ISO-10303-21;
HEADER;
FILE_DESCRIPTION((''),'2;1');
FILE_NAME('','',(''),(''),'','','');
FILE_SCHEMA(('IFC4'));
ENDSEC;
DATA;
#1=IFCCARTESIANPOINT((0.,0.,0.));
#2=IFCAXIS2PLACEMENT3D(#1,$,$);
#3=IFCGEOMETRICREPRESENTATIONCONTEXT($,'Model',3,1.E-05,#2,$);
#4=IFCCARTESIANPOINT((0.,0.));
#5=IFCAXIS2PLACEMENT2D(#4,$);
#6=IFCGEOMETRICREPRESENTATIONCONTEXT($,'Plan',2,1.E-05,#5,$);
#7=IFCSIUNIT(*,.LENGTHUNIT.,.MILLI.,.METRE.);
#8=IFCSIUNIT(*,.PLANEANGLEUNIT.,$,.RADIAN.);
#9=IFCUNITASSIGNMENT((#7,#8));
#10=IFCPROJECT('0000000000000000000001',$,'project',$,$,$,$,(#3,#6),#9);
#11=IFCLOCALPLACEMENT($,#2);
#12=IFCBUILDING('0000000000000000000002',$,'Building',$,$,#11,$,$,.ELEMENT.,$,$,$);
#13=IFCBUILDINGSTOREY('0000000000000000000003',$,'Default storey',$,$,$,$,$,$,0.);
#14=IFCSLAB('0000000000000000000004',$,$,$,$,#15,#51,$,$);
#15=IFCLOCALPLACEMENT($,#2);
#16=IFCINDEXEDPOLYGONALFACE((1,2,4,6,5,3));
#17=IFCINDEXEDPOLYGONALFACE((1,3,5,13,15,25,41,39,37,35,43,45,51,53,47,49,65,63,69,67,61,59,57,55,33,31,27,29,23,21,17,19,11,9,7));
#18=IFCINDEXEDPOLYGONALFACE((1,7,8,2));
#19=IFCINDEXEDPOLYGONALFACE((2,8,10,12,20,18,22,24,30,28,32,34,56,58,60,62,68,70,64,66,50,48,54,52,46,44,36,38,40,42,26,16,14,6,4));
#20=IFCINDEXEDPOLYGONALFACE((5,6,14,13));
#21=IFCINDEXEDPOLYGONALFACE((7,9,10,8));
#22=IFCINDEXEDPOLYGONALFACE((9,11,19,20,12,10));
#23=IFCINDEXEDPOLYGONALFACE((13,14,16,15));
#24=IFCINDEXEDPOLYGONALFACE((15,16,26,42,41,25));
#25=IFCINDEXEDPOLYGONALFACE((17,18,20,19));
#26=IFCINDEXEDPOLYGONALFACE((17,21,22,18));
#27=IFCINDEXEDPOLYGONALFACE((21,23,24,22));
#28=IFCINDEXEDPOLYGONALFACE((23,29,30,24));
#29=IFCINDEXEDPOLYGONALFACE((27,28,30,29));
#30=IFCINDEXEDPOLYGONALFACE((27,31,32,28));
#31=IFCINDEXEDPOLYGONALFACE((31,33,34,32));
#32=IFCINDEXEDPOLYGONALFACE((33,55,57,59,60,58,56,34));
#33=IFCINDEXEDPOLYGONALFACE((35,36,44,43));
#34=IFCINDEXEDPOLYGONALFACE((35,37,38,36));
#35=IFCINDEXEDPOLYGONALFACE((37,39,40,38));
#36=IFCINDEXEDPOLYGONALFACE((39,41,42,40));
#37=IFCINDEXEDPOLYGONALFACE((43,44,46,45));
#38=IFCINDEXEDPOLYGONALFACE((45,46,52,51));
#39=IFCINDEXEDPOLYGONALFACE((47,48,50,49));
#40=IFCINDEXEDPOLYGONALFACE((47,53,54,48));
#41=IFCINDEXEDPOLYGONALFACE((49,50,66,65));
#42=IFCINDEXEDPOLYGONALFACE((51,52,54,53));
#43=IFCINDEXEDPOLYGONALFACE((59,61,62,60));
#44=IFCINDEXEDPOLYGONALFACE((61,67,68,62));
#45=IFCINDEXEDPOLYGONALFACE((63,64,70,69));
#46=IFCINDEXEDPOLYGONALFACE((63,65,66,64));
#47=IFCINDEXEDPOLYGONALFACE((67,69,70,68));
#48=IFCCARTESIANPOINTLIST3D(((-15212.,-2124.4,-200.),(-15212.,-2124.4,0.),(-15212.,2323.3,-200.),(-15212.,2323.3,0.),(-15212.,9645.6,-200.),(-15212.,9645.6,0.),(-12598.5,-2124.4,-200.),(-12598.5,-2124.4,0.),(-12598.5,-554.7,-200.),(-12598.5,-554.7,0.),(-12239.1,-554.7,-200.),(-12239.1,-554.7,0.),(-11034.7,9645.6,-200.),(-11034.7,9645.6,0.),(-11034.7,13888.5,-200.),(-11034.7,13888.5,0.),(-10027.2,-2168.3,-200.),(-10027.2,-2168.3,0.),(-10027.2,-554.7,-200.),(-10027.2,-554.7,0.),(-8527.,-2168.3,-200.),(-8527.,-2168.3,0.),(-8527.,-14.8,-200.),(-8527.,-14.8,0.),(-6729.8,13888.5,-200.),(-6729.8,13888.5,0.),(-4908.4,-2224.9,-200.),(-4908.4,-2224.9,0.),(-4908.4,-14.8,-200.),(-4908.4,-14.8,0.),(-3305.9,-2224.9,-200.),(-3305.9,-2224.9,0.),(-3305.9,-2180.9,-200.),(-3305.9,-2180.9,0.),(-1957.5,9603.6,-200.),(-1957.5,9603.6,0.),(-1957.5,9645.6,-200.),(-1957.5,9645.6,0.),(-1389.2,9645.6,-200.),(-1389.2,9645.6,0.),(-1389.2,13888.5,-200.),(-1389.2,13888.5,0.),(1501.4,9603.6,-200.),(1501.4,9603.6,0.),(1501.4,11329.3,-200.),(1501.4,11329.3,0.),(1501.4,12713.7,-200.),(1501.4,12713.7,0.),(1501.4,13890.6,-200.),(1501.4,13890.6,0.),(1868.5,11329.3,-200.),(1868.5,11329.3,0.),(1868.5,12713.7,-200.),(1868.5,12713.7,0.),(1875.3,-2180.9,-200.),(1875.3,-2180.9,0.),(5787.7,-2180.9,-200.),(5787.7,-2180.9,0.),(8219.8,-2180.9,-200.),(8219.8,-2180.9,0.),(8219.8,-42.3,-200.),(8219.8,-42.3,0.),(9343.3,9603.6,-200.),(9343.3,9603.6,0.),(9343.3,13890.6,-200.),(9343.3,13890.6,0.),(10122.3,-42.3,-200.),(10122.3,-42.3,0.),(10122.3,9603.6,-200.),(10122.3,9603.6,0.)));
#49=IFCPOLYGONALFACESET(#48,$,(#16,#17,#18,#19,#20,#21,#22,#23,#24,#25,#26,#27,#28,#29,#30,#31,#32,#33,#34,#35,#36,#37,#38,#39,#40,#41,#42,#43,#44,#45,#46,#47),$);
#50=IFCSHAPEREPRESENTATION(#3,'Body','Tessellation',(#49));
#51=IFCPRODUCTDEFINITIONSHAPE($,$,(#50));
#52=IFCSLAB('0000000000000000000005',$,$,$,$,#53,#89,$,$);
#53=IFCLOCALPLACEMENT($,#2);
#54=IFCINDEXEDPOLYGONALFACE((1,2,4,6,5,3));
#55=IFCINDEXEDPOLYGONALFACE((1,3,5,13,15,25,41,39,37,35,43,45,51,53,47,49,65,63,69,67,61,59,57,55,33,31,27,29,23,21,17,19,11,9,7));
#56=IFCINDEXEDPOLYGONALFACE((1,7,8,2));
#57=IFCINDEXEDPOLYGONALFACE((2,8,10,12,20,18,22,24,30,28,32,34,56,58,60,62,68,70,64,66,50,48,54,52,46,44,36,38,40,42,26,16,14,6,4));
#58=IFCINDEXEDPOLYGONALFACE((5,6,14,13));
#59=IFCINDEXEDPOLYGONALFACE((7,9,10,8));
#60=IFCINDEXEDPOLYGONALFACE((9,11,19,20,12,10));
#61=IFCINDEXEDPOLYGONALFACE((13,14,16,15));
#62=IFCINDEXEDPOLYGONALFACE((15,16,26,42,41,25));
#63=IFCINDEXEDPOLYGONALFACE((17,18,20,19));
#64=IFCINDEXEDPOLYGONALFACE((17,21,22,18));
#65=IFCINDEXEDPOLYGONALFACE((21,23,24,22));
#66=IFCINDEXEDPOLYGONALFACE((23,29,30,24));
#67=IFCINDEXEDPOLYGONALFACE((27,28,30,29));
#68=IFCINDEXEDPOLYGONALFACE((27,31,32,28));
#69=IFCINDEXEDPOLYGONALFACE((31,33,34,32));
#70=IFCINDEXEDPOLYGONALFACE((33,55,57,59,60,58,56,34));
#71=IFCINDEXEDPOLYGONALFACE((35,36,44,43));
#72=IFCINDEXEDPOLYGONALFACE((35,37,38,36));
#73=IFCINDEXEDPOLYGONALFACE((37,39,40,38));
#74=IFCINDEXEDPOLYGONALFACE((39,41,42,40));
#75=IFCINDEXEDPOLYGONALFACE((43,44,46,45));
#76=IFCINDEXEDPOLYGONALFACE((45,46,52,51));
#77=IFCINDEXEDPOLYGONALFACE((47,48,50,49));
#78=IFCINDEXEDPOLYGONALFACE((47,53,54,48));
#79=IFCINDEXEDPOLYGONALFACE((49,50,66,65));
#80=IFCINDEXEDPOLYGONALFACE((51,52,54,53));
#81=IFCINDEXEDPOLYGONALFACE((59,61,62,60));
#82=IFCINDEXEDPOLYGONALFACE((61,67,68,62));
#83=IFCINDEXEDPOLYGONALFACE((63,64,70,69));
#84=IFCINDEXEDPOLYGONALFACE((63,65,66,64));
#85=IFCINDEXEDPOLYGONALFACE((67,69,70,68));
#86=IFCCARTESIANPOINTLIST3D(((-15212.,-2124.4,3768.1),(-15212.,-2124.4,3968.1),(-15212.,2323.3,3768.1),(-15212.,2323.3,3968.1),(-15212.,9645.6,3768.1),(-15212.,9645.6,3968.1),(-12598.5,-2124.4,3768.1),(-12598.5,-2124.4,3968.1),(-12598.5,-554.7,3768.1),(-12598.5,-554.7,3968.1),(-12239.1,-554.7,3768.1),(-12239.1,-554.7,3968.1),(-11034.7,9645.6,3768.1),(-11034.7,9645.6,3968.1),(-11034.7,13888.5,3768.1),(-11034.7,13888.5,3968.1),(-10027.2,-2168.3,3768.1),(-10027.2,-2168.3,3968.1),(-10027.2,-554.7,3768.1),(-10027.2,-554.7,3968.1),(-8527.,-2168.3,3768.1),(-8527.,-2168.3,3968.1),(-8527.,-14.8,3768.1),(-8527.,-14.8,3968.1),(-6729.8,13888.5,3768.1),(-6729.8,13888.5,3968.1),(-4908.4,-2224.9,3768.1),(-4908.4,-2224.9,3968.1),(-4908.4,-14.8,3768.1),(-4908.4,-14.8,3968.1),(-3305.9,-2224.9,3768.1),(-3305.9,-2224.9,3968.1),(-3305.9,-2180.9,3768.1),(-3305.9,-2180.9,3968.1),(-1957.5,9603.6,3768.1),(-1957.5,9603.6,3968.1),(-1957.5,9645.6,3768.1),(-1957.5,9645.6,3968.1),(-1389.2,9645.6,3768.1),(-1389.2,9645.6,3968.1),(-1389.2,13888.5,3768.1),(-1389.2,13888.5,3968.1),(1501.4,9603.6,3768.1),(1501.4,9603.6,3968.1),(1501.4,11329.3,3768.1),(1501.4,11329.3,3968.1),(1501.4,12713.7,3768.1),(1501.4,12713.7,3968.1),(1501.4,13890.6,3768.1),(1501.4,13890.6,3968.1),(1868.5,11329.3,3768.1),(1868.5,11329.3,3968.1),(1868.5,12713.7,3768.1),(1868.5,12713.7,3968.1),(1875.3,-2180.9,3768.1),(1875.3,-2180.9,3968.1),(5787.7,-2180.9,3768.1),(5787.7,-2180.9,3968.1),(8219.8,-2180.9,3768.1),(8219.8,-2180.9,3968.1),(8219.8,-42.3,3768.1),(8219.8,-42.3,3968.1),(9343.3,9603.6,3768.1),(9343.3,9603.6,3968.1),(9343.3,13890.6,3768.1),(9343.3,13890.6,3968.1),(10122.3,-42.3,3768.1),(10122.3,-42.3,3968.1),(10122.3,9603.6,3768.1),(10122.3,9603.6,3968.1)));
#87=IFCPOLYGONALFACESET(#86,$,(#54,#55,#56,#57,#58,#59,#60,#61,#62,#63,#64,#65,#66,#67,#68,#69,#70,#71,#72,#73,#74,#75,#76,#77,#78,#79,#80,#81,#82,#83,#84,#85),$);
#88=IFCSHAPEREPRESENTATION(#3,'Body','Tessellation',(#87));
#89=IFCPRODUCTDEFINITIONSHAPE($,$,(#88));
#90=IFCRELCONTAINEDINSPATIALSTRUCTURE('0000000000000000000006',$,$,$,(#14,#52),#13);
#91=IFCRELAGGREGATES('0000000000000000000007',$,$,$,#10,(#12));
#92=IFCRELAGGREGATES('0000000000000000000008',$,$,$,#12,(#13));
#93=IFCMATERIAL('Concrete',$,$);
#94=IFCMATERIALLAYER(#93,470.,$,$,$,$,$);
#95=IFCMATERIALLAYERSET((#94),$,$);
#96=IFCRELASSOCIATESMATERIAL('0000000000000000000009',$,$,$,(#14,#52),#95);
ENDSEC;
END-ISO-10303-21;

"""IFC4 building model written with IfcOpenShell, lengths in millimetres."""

from ifc_helpers import new_model, si_unit, frame, origin, origin_2d, place, context, project, spatial, polyline, outline, extrude, material, layer, layer_set, layer_usage, element, save


model = new_model("IFC4")

# Units and contexts
model_context = context("Model", 3, precision=1e-05, world=origin())
plan_context = context("Plan", 2, precision=1e-05, world=origin_2d())
ifc_project = project(units=[si_unit("LENGTHUNIT", "METRE", prefix="MILLI"), si_unit("PLANEANGLEUNIT", "RADIAN")], contexts=[model_context, plan_context])

# Building, storey
placement = place(None, origin())
building = spatial("IfcBuilding", under=ifc_project, at=placement, Name="Building", CompositionType="ELEMENT")
storey = spatial("IfcBuildingStorey", under=building, Name="Default storey", Elevation=0.0)

# Slabs
ifc_material_1 = material(Name="Concrete")
ifc_layer_1 = layer(ifc_material_1, 470.0)
ifc_layer_set_1 = layer_set([ifc_layer_1])
ifc_layer_usage_1 = layer_usage(ifc_layer_set_1, "AXIS3", "POSITIVE", 0.0)
element("IfcSlab", 1, at=placement, inside=storey, material=ifc_layer_usage_1, context=model_context, shape_type="SweptSolid", body=[
    extrude(outline(polyline([(9343.3, 9603.6), (9343.3, 13890.6), (1501.4, 13890.6), (1501.4, 12713.7), (1868.5, 12713.7), (1868.5, 11329.3), (1501.4, 11329.3), (1501.4, 9603.6), (-1957.5, 9603.6), (-1957.5, 9645.6), (-1389.2, 9645.6), (-1389.2, 13888.5), (-6729.8, 13888.5), (-11034.7, 13888.5), (-11034.7, 9645.6), (-15212.0, 9645.6), (-15212.0, 2323.3), (-15212.0, -2124.4), (-12598.5, -2124.4), (-12598.5, -554.7), (-12239.1, -554.7), (-10027.2, -554.7), (-10027.2, -2168.3), (-8527.0, -2168.3), (-8527.0, -14.8), (-4908.4, -14.8), (-4908.4, -2224.9), (-3305.9, -2224.9), (-3305.9, -2180.9), (1875.3, -2180.9), (5787.7, -2180.9), (8219.8, -2180.9), (8219.8, -42.3), (10122.3, -42.3), (10122.3, 9603.6), (9343.3, 9603.6)])), frame((0.0, 0.0, -200.0), z_axis=(0.0, 0.0, 1000.0), x_axis=(1000.0, 0.0, 0.0)), (0.0, 0.0, 1.0), 200.0),
])
element("IfcSlab", 2, at=placement, inside=storey, material=ifc_layer_usage_1, context=model_context, shape_type="SweptSolid", body=[
    extrude(outline(polyline([(9343.3, 9603.6), (9343.3, 13890.6), (1501.4, 13890.6), (1501.4, 12713.7), (1868.5, 12713.7), (1868.5, 11329.3), (1501.4, 11329.3), (1501.4, 9603.6), (-1957.5, 9603.6), (-1957.5, 9645.6), (-1389.2, 9645.6), (-1389.2, 13888.5), (-6729.8, 13888.5), (-11034.7, 13888.5), (-11034.7, 9645.6), (-15212.0, 9645.6), (-15212.0, 2323.3), (-15212.0, -2124.4), (-12598.5, -2124.4), (-12598.5, -554.7), (-12239.1, -554.7), (-10027.2, -554.7), (-10027.2, -2168.3), (-8527.0, -2168.3), (-8527.0, -14.8), (-4908.4, -14.8), (-4908.4, -2224.9), (-3305.9, -2224.9), (-3305.9, -2180.9), (1875.3, -2180.9), (5787.7, -2180.9), (8219.8, -2180.9), (8219.8, -42.3), (10122.3, -42.3), (10122.3, 9603.6), (9343.3, 9603.6)])), frame((0.0, 0.0, 3968.1), z_axis=(0.0, 0.0, 1000.0), x_axis=(1000.0, 0.0, 0.0)), (0.0, 0.0, -1.0), 200.0),
])

save(model, "model.ifc")
